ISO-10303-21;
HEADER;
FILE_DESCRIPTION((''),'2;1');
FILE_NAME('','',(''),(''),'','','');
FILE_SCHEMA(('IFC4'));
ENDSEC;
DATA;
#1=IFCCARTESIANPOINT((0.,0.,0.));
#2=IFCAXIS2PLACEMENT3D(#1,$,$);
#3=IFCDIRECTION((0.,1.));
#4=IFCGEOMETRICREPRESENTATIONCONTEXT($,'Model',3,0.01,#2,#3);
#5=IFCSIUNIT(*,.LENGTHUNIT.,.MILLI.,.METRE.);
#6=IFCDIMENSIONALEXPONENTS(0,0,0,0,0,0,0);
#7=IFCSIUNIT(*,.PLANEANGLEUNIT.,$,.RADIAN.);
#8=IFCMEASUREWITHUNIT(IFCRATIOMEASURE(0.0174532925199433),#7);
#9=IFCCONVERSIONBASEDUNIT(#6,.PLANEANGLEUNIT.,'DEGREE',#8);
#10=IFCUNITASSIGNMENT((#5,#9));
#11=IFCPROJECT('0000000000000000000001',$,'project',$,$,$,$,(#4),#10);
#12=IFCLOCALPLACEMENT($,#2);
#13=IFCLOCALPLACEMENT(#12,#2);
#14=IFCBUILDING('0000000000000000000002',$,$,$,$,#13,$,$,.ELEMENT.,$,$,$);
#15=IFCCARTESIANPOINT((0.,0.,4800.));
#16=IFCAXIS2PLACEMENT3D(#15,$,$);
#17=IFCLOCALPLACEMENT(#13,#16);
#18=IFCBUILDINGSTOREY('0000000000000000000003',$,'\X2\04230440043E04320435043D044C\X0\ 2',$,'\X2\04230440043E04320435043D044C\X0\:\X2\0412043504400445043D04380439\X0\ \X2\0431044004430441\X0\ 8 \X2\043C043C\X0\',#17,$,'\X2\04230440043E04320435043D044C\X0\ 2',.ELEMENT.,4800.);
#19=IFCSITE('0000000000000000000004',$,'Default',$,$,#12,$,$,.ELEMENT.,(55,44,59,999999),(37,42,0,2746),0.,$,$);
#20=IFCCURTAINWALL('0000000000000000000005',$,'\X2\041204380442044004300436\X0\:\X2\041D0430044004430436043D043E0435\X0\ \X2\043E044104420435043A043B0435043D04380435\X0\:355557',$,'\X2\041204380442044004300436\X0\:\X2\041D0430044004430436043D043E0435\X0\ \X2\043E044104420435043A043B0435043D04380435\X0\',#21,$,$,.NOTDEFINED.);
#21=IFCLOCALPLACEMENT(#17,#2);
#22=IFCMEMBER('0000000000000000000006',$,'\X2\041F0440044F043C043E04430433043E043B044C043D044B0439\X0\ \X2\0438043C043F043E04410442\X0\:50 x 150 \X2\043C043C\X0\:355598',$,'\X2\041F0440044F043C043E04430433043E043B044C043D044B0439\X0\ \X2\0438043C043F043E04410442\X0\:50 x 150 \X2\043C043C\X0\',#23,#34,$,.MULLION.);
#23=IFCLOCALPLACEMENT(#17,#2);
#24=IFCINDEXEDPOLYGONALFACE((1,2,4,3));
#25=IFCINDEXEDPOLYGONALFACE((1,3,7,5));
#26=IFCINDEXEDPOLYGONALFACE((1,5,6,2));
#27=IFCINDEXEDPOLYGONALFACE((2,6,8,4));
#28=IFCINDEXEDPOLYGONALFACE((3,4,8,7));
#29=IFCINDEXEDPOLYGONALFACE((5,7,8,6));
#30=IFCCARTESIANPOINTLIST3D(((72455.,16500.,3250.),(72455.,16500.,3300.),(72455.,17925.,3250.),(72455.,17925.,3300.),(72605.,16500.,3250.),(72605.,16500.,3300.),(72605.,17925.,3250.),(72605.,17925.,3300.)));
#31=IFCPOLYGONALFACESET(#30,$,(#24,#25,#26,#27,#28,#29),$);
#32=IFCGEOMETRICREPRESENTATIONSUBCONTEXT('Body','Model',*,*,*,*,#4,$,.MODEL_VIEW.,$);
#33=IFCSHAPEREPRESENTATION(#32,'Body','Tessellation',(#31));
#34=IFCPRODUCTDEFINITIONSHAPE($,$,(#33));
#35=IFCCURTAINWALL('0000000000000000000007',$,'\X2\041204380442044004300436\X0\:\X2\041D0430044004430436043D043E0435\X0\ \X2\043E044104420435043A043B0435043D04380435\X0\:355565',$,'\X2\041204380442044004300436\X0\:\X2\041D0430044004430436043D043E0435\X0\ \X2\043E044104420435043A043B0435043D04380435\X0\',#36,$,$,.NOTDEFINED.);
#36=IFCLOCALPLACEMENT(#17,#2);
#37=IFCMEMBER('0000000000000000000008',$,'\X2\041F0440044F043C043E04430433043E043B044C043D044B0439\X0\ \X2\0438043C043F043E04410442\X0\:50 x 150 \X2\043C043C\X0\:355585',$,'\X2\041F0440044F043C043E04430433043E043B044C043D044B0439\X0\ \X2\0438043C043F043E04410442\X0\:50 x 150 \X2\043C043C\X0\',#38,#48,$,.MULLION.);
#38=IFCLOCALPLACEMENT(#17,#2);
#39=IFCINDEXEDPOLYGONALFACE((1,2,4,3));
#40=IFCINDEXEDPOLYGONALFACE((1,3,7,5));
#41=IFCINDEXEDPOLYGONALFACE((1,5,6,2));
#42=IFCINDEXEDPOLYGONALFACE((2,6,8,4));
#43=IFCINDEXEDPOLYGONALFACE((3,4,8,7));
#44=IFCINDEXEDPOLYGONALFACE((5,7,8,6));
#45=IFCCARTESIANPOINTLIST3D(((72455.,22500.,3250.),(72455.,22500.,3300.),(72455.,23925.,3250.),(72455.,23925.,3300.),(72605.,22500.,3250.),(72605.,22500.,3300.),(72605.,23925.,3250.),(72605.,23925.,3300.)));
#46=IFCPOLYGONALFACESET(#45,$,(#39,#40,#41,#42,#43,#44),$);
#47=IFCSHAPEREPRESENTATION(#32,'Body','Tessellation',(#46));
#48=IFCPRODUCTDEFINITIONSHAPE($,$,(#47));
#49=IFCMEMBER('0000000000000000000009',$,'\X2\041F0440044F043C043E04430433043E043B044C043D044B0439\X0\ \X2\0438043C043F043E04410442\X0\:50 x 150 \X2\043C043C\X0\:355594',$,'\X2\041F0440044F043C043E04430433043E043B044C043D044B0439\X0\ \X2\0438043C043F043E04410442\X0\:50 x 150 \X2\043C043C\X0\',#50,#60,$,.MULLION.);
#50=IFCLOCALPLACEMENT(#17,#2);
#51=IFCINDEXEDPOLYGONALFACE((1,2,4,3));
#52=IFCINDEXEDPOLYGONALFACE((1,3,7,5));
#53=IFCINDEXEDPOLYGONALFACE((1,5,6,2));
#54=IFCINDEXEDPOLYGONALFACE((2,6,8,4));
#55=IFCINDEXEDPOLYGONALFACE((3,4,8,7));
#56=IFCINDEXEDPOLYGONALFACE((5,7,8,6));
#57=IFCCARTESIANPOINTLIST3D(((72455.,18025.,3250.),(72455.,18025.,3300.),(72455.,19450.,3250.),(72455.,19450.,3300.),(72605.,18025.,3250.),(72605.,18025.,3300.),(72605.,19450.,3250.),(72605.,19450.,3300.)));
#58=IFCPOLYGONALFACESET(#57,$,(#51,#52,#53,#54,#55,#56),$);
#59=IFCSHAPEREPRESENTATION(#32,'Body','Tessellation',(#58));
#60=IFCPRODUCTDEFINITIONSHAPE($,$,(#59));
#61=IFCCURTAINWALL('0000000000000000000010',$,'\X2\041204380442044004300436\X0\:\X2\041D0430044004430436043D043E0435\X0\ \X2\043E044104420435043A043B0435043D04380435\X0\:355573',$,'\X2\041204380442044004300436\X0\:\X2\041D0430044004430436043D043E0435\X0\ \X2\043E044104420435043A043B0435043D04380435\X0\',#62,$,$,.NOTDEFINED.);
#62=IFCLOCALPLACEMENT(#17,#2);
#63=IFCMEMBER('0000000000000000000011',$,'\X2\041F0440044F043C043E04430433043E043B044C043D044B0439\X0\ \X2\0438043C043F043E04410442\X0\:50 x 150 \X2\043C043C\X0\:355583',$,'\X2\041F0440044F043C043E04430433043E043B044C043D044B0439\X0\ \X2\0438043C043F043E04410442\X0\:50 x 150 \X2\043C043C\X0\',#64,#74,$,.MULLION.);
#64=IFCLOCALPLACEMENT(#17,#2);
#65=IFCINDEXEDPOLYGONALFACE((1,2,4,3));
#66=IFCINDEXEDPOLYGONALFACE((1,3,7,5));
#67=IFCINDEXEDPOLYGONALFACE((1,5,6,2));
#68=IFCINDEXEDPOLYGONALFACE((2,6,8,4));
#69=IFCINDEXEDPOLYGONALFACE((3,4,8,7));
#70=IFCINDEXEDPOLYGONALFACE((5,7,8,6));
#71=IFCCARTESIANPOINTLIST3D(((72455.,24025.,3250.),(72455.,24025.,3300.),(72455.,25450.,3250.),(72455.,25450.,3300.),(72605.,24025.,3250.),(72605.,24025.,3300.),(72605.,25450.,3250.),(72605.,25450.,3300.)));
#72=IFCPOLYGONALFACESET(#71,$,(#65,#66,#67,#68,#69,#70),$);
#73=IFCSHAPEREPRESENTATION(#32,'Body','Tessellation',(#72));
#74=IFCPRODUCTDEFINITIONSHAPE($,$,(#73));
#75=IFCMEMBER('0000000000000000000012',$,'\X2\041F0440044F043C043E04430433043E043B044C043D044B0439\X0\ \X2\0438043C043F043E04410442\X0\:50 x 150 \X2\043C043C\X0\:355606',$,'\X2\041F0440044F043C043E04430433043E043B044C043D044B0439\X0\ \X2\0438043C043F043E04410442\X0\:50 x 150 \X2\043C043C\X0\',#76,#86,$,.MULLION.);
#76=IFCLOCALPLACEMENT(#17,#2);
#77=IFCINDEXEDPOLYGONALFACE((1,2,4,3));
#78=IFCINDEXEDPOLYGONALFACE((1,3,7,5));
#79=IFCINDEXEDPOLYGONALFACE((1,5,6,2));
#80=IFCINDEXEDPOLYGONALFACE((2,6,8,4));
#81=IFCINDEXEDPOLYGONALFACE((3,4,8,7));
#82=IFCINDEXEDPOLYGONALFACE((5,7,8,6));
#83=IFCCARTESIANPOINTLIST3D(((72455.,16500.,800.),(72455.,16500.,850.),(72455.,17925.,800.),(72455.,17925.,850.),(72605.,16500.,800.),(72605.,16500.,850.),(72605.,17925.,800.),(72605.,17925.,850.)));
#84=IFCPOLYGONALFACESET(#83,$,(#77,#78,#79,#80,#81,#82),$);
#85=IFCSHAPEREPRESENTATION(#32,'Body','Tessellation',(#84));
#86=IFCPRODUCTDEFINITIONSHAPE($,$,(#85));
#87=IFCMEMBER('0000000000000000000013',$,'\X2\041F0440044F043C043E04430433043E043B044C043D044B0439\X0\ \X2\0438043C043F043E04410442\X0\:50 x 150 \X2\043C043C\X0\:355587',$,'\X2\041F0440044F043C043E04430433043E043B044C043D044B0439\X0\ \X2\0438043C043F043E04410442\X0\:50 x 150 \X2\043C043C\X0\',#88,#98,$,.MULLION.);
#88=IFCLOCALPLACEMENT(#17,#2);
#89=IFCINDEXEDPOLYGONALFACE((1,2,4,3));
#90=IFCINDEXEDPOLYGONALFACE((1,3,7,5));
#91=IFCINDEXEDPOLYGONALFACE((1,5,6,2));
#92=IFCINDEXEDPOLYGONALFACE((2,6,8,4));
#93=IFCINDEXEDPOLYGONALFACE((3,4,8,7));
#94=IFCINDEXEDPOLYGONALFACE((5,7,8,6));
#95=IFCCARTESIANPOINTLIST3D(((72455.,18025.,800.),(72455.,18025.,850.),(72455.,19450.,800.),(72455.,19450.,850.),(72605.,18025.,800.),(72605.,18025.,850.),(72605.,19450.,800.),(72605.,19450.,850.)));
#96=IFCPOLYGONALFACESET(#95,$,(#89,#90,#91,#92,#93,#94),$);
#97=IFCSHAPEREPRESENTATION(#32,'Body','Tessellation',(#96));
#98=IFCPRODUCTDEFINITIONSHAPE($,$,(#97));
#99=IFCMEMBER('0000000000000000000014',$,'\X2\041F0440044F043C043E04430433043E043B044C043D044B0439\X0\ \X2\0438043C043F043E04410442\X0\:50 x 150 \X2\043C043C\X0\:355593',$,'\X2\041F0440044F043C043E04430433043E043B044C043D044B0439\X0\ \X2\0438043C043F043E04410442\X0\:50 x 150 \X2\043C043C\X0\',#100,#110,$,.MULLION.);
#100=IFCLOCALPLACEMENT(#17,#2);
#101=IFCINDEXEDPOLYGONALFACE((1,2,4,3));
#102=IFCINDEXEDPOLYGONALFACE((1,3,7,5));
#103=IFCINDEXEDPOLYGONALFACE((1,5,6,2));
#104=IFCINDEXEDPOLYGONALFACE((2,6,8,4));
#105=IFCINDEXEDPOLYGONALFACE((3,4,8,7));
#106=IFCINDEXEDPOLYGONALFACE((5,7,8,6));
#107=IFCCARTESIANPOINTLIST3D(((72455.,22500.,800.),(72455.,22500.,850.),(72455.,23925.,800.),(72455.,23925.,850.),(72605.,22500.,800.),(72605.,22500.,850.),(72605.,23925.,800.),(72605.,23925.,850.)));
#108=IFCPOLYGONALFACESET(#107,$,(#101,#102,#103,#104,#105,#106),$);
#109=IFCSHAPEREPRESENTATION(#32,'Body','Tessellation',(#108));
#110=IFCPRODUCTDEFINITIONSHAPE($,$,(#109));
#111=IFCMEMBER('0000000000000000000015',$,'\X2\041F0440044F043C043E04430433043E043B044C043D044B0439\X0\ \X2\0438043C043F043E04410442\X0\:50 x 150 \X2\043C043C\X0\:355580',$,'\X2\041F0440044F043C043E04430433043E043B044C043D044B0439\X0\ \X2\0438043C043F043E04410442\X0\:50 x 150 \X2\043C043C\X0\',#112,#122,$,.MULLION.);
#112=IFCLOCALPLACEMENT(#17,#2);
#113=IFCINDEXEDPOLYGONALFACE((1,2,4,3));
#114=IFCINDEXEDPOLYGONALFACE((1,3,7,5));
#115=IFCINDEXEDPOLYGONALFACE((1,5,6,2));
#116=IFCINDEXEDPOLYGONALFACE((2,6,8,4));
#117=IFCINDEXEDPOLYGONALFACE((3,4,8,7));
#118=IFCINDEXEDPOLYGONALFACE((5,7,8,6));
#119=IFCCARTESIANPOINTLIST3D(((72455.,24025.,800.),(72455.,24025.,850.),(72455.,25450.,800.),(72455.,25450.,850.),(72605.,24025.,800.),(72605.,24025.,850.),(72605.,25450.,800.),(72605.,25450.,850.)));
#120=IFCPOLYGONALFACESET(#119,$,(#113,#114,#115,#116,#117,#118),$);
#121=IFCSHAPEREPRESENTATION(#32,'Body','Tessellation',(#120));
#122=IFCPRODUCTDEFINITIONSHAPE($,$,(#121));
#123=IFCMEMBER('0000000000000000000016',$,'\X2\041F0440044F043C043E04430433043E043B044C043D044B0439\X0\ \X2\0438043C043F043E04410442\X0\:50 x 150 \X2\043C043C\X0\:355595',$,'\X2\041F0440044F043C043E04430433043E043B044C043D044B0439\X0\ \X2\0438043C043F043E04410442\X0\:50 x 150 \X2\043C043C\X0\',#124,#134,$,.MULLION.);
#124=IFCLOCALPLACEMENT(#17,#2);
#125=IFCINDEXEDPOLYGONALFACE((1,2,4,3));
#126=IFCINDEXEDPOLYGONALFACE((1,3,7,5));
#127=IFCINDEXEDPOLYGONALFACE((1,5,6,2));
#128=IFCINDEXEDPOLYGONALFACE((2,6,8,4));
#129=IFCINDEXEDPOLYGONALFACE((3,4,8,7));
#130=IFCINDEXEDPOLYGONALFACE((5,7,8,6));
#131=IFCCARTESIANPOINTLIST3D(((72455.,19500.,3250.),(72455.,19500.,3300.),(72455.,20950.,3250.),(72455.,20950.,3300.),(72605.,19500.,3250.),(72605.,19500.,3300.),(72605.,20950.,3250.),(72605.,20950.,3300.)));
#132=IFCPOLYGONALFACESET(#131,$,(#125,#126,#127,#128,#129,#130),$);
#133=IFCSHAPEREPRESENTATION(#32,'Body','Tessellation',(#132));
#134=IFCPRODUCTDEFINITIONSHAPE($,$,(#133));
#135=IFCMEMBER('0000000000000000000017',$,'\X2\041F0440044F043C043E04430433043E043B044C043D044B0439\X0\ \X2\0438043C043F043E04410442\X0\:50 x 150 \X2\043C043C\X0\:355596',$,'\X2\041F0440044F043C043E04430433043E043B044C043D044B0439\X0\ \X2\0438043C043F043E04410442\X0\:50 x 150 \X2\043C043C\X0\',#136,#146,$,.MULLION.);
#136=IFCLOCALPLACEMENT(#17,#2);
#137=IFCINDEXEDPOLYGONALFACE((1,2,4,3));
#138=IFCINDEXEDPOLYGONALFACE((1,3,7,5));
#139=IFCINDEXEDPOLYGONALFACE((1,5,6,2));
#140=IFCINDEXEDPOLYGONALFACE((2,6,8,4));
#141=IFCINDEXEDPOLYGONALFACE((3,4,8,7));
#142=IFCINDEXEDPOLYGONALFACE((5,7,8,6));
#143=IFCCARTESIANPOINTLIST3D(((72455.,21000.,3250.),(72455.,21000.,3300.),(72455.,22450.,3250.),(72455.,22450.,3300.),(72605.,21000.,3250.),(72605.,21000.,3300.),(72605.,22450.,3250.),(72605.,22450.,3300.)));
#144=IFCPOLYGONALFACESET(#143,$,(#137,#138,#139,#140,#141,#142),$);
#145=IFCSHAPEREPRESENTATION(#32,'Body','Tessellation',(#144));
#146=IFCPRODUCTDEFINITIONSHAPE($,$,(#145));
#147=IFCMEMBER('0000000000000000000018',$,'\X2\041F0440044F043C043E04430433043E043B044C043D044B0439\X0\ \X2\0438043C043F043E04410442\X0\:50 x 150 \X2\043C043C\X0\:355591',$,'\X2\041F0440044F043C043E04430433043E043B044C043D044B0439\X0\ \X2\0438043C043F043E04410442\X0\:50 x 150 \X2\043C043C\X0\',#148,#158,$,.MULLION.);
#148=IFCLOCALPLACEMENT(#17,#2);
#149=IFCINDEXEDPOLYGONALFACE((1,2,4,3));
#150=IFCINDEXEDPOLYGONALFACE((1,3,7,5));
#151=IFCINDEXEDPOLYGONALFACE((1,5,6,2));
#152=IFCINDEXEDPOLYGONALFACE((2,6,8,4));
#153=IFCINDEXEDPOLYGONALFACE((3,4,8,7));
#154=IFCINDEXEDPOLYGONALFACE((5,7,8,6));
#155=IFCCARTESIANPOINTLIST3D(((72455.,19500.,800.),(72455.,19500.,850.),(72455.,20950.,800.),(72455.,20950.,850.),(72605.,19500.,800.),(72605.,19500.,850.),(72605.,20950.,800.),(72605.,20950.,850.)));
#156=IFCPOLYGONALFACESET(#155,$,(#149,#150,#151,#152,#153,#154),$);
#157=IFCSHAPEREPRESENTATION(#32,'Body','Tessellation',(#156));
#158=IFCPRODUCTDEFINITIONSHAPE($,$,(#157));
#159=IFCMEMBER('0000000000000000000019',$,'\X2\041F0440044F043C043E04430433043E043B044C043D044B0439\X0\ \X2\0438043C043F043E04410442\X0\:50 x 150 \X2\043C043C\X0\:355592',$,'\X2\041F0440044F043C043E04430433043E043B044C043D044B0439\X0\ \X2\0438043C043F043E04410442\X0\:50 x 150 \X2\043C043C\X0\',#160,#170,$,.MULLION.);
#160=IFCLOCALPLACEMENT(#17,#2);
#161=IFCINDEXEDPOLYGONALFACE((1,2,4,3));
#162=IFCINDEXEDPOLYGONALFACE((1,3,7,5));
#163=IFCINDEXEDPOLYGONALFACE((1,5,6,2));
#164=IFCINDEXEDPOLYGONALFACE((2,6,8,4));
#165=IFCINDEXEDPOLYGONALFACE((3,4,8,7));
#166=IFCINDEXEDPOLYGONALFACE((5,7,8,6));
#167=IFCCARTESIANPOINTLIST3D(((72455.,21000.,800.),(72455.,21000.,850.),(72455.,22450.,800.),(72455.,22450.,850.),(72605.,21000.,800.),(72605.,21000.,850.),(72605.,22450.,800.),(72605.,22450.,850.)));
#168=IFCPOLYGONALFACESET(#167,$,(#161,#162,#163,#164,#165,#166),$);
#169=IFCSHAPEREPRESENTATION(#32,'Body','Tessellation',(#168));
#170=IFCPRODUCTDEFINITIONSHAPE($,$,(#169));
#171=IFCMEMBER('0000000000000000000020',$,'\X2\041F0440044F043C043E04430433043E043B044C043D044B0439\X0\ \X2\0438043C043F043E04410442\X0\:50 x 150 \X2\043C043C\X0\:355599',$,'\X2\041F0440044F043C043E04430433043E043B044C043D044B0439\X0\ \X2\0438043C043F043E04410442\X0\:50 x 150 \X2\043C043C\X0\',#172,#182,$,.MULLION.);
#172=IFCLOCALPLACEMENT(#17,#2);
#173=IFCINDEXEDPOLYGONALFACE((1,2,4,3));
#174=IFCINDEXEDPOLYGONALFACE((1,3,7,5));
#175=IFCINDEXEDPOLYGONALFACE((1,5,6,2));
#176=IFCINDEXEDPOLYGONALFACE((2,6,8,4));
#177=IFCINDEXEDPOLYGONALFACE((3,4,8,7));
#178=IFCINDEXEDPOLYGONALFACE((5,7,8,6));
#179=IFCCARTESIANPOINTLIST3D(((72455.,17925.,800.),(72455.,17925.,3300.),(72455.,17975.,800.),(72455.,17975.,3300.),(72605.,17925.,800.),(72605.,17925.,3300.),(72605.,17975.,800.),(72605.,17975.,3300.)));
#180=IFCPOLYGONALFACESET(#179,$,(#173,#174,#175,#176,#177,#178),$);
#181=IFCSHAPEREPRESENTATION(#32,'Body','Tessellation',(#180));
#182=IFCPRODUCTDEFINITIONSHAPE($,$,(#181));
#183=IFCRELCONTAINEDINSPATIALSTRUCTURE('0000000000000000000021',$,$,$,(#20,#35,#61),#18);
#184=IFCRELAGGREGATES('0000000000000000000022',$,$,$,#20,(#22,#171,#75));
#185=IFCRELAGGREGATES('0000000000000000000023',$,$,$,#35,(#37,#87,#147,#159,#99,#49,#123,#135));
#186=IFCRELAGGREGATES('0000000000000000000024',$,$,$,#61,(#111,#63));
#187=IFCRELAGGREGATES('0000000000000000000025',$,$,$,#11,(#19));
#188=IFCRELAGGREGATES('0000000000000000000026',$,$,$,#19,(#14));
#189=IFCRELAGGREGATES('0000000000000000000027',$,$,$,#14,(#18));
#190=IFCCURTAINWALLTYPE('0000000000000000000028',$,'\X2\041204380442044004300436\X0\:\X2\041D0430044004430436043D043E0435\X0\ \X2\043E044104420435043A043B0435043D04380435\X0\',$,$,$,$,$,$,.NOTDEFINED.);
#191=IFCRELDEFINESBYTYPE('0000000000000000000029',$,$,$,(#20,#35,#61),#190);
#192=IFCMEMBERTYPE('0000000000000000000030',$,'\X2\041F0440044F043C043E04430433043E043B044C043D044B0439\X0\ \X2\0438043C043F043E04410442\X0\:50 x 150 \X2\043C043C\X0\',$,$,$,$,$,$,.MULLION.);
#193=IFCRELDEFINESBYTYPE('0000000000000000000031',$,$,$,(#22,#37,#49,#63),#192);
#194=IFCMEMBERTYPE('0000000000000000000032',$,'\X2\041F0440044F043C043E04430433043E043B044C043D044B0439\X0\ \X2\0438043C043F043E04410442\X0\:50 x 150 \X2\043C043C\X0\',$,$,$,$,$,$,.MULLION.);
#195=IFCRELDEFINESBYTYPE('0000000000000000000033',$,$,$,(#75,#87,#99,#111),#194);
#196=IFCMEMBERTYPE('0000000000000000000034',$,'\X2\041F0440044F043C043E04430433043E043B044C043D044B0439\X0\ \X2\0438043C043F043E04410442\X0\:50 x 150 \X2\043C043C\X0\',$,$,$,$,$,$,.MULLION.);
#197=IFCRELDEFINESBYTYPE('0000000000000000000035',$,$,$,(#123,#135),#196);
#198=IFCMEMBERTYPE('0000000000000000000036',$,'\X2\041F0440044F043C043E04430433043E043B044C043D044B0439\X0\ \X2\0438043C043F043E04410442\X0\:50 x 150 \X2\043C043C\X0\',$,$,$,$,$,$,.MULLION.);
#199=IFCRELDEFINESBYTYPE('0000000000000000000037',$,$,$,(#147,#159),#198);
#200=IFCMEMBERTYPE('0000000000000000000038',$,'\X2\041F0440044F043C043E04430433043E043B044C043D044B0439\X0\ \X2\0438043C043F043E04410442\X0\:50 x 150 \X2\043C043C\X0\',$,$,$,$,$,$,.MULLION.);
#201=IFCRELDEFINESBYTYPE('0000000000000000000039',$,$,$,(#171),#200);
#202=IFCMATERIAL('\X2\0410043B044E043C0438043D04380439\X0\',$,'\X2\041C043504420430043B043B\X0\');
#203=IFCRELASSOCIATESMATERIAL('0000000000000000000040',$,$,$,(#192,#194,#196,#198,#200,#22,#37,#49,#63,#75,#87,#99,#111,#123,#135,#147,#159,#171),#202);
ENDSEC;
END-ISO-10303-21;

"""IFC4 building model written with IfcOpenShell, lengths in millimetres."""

from ifc_helpers import new_model, entity, si_unit, converted_unit, direction, frame, origin, origin_2d_with_axis, place, context, subcontext, project, spatial, rectangle, extrude, source, transform, mapped, material, material_profile, profile_set, profile_usage, type_object, type_shapes, element, aggregate, save


model = new_model("IFC4")

# Units and contexts
model_context = context("Model", 3, precision=0.01, world=origin(), true_north=direction((0.0, 1.0)))
body_context = subcontext(model_context, "Body", "Model", "MODEL_VIEW")
ifc_project = project(units=[si_unit("LENGTHUNIT", "METRE", prefix="MILLI"), converted_unit("PLANEANGLEUNIT", "DEGREE", entity("IfcRatioMeasure", 0.0174532925199433), si_unit("PLANEANGLEUNIT", "RADIAN"), dimensions=[0, 0, 0, 0, 0, 0, 0])], contexts=[model_context])

# Site, building, storey
site_placement = place(None, origin())
site = spatial("IfcSite", under=ifc_project, at=site_placement, Name="Default", CompositionType="ELEMENT", RefLatitude=(55, 44, 59, 999999), RefLongitude=(37, 42, 0, 2746), RefElevation=0.0)
building_placement = place(site_placement, origin())
building = spatial("IfcBuilding", under=site, at=building_placement, CompositionType="ELEMENT")
storey_placement = place(building_placement, frame((0.0, 0.0, 4800.0)))
storey = spatial("IfcBuildingStorey", under=building, at=storey_placement, Name="Уровень 2", ObjectType="Уровень:Верхний брус 8 мм", LongName="Уровень 2", CompositionType="ELEMENT", Elevation=4800.0)

# Curtain wall, member
curtain_wall_type = type_object("IfcCurtainWallType", Name="Витраж:Наружное остекление", PredefinedType="NOTDEFINED")
curtain_wall_1_placement = place(storey_placement, frame((0.0, 0.0, -4800.0)))
curtain_wall_1 = element("IfcCurtainWall", 1, at=curtain_wall_1_placement, inside=storey, type_object=curtain_wall_type, Name="Витраж:Наружное остекление:355557", ObjectType="Витраж:Наружное остекление", PredefinedType="NOTDEFINED")
ifc_material = material(Name="Алюминий", Category="Металл")
ifc_material_profile = material_profile(ifc_material, rectangle(XDim=150.0, YDim=50.0, at=origin_2d_with_axis()), Name="50 x 150 мм")
ifc_profile_set = profile_set([ifc_material_profile], Name="50 x 150 мм")
ifc_profile_usage_1 = profile_usage(ifc_profile_set)
member_type_1 = type_object("IfcMemberType", Name="Прямоугольный импост:50 x 150 мм", PredefinedType="MULLION", material=ifc_profile_set)
shared_shape_1 = source(origin(), body_context, "Body", "SweptSolid", [
    extrude(rectangle(XDim=150.0, YDim=50.0, at=origin_2d_with_axis()), frame((-25.0, 0.0, -1425.0), z_axis=(0.0, 0.0, 1.0), x_axis=(0.0, -1.0, 0.0)), (0.0, 0.0, 1.0), 1425.0),
])
type_shapes(member_type_1, [shared_shape_1])
member_1_placement = place(storey_placement, frame((72530.0, 17925.0, 3300.0), z_axis=(0.0, 1.0, 0.0), x_axis=(0.0, 0.0, 1.0)))
member_1 = element("IfcMember", 2, at=member_1_placement, type_object=member_type_1, material=ifc_profile_usage_1, Name="Прямоугольный импост:50 x 150 мм:355598", ObjectType="Прямоугольный импост:50 x 150 мм", PredefinedType="MULLION", context=body_context, shape_type="MappedRepresentation", body=[
    mapped(shared_shape_1, transform((0.0, 0.0, 0.0), scale=1.0)),
])

# Curtain wall, members
curtain_wall_2_placement = place(storey_placement, frame((0.0, 0.0, -4800.0)))
curtain_wall_2 = element("IfcCurtainWall", 3, at=curtain_wall_2_placement, inside=storey, type_object=curtain_wall_type, Name="Витраж:Наружное остекление:355565", ObjectType="Витраж:Наружное остекление", PredefinedType="NOTDEFINED")
ifc_profile_usage_2 = profile_usage(ifc_profile_set)
member_2_placement = place(storey_placement, frame((72530.0, 23925.0, 3300.0), z_axis=(0.0, 1.0, 0.0), x_axis=(0.0, 0.0, 1.0)))
member_2 = element("IfcMember", 4, at=member_2_placement, type_object=member_type_1, material=ifc_profile_usage_2, Name="Прямоугольный импост:50 x 150 мм:355585", ObjectType="Прямоугольный импост:50 x 150 мм", PredefinedType="MULLION", context=body_context, shape_type="MappedRepresentation", body=[
    mapped(shared_shape_1, transform((0.0, 0.0, 0.0), scale=1.0)),
])
ifc_profile_usage_3 = profile_usage(ifc_profile_set)
member_3_placement = place(storey_placement, frame((72530.0, 19450.0, 3300.0), z_axis=(0.0, 1.0, 0.0), x_axis=(0.0, 0.0, 1.0)))
member_3 = element("IfcMember", 5, at=member_3_placement, type_object=member_type_1, material=ifc_profile_usage_3, Name="Прямоугольный импост:50 x 150 мм:355594", ObjectType="Прямоугольный импост:50 x 150 мм", PredefinedType="MULLION", context=body_context, shape_type="MappedRepresentation", body=[
    mapped(shared_shape_1, transform((0.0, 0.0, 0.0), scale=1.0)),
])

# Curtain wall, member
curtain_wall_3_placement = place(storey_placement, frame((0.0, 0.0, -4800.0)))
curtain_wall_3 = element("IfcCurtainWall", 6, at=curtain_wall_3_placement, inside=storey, type_object=curtain_wall_type, Name="Витраж:Наружное остекление:355573", ObjectType="Витраж:Наружное остекление", PredefinedType="NOTDEFINED")
ifc_profile_usage_4 = profile_usage(ifc_profile_set)
member_4_placement = place(storey_placement, frame((72530.0, 25450.0, 3300.0), z_axis=(0.0, 1.0, 0.0), x_axis=(0.0, 0.0, 1.0)))
member_4 = element("IfcMember", 7, at=member_4_placement, type_object=member_type_1, material=ifc_profile_usage_4, Name="Прямоугольный импост:50 x 150 мм:355583", ObjectType="Прямоугольный импост:50 x 150 мм", PredefinedType="MULLION", context=body_context, shape_type="MappedRepresentation", body=[
    mapped(shared_shape_1, transform((0.0, 0.0, 0.0), scale=1.0)),
])

# Members
ifc_profile_usage_5 = profile_usage(ifc_profile_set)
member_type_2 = type_object("IfcMemberType", Name="Прямоугольный импост:50 x 150 мм", PredefinedType="MULLION", material=ifc_profile_set)
shared_shape_2 = source(origin(), body_context, "Body", "SweptSolid", [
    extrude(rectangle(XDim=150.0, YDim=50.0, at=origin_2d_with_axis()), frame((-25.0, 0.0, -1425.0), z_axis=(0.0, 0.0, 1.0), x_axis=(0.0, -1.0, 0.0)), (0.0, 0.0, 1.0), 1425.0),
])
type_shapes(member_type_2, [shared_shape_2])
member_5_placement = place(storey_placement, frame((72530.0, 16500.0, 800.0), z_axis=(0.0, -1.0, 0.0), x_axis=(0.0, 0.0, -1.0)))
member_5 = element("IfcMember", 8, at=member_5_placement, type_object=member_type_2, material=ifc_profile_usage_5, Name="Прямоугольный импост:50 x 150 мм:355606", ObjectType="Прямоугольный импост:50 x 150 мм", PredefinedType="MULLION", context=body_context, shape_type="MappedRepresentation", body=[
    mapped(shared_shape_2, transform((0.0, 0.0, 0.0), scale=1.0)),
])
ifc_profile_usage_6 = profile_usage(ifc_profile_set)
member_6_placement = place(storey_placement, frame((72530.0, 18025.0, 800.0), z_axis=(0.0, -1.0, 0.0), x_axis=(0.0, 0.0, -1.0)))
member_6 = element("IfcMember", 9, at=member_6_placement, type_object=member_type_2, material=ifc_profile_usage_6, Name="Прямоугольный импост:50 x 150 мм:355587", ObjectType="Прямоугольный импост:50 x 150 мм", PredefinedType="MULLION", context=body_context, shape_type="MappedRepresentation", body=[
    mapped(shared_shape_2, transform((0.0, 0.0, 0.0), scale=1.0)),
])
ifc_profile_usage_7 = profile_usage(ifc_profile_set)
member_7_placement = place(storey_placement, frame((72530.0, 22500.0, 800.0), z_axis=(0.0, -1.0, 0.0), x_axis=(0.0, 0.0, -1.0)))
member_7 = element("IfcMember", 10, at=member_7_placement, type_object=member_type_2, material=ifc_profile_usage_7, Name="Прямоугольный импост:50 x 150 мм:355593", ObjectType="Прямоугольный импост:50 x 150 мм", PredefinedType="MULLION", context=body_context, shape_type="MappedRepresentation", body=[
    mapped(shared_shape_2, transform((0.0, 0.0, 0.0), scale=1.0)),
])
ifc_profile_usage_8 = profile_usage(ifc_profile_set)
member_8_placement = place(storey_placement, frame((72530.0, 24025.0, 800.0), z_axis=(0.0, -1.0, 0.0), x_axis=(0.0, 0.0, -1.0)))
member_8 = element("IfcMember", 11, at=member_8_placement, type_object=member_type_2, material=ifc_profile_usage_8, Name="Прямоугольный импост:50 x 150 мм:355580", ObjectType="Прямоугольный импост:50 x 150 мм", PredefinedType="MULLION", context=body_context, shape_type="MappedRepresentation", body=[
    mapped(shared_shape_2, transform((0.0, 0.0, 0.0), scale=1.0)),
])
ifc_profile_usage_9 = profile_usage(ifc_profile_set)
member_type_3 = type_object("IfcMemberType", Name="Прямоугольный импост:50 x 150 мм", PredefinedType="MULLION", material=ifc_profile_set)
shared_shape_3 = source(origin(), body_context, "Body", "SweptSolid", [
    extrude(rectangle(XDim=150.0, YDim=50.0, at=origin_2d_with_axis()), frame((-25.0, 0.0, -1450.0), z_axis=(0.0, 0.0, 1.0), x_axis=(0.0, -1.0, 0.0)), (0.0, 0.0, 1.0), 1450.0),
])
type_shapes(member_type_3, [shared_shape_3])
member_9_placement = place(storey_placement, frame((72530.0, 20950.0, 3300.0), z_axis=(0.0, 1.0, 0.0), x_axis=(0.0, 0.0, 1.0)))
member_9 = element("IfcMember", 12, at=member_9_placement, type_object=member_type_3, material=ifc_profile_usage_9, Name="Прямоугольный импост:50 x 150 мм:355595", ObjectType="Прямоугольный импост:50 x 150 мм", PredefinedType="MULLION", context=body_context, shape_type="MappedRepresentation", body=[
    mapped(shared_shape_3, transform((0.0, 0.0, 0.0), scale=1.0)),
])
ifc_profile_usage_10 = profile_usage(ifc_profile_set)
member_10_placement = place(storey_placement, frame((72530.0, 22450.0, 3300.0), z_axis=(0.0, 1.0, 0.0), x_axis=(0.0, 0.0, 1.0)))
member_10 = element("IfcMember", 13, at=member_10_placement, type_object=member_type_3, material=ifc_profile_usage_10, Name="Прямоугольный импост:50 x 150 мм:355596", ObjectType="Прямоугольный импост:50 x 150 мм", PredefinedType="MULLION", context=body_context, shape_type="MappedRepresentation", body=[
    mapped(shared_shape_3, transform((0.0, 0.0, 0.0), scale=1.0)),
])
ifc_profile_usage_11 = profile_usage(ifc_profile_set)
member_type_4 = type_object("IfcMemberType", Name="Прямоугольный импост:50 x 150 мм", PredefinedType="MULLION", material=ifc_profile_set)
shared_shape_4 = source(origin(), body_context, "Body", "SweptSolid", [
    extrude(rectangle(XDim=150.0, YDim=50.0, at=origin_2d_with_axis()), frame((-25.0, 0.0, -1450.0), z_axis=(0.0, 0.0, 1.0), x_axis=(0.0, -1.0, 0.0)), (0.0, 0.0, 1.0), 1450.0),
])
type_shapes(member_type_4, [shared_shape_4])
member_11_placement = place(storey_placement, frame((72530.0, 19500.0, 800.0), z_axis=(0.0, -1.0, 0.0), x_axis=(0.0, 0.0, -1.0)))
member_11 = element("IfcMember", 14, at=member_11_placement, type_object=member_type_4, material=ifc_profile_usage_11, Name="Прямоугольный импост:50 x 150 мм:355591", ObjectType="Прямоугольный импост:50 x 150 мм", PredefinedType="MULLION", context=body_context, shape_type="MappedRepresentation", body=[
    mapped(shared_shape_4, transform((0.0, 0.0, 0.0), scale=1.0)),
])
ifc_profile_usage_12 = profile_usage(ifc_profile_set)
member_12_placement = place(storey_placement, frame((72530.0, 21000.0, 800.0), z_axis=(0.0, -1.0, 0.0), x_axis=(0.0, 0.0, -1.0)))
member_12 = element("IfcMember", 15, at=member_12_placement, type_object=member_type_4, material=ifc_profile_usage_12, Name="Прямоугольный импост:50 x 150 мм:355592", ObjectType="Прямоугольный импост:50 x 150 мм", PredefinedType="MULLION", context=body_context, shape_type="MappedRepresentation", body=[
    mapped(shared_shape_4, transform((0.0, 0.0, 0.0), scale=1.0)),
])
ifc_profile_usage_13 = profile_usage(ifc_profile_set)
member_type_5 = type_object("IfcMemberType", Name="Прямоугольный импост:50 x 150 мм", PredefinedType="MULLION", material=ifc_profile_set)
shared_shape_5 = source(origin(), body_context, "Body", "SweptSolid", [
    extrude(rectangle(XDim=150.0, YDim=50.0, at=origin_2d_with_axis()), frame((-25.0, 0.0, -2500.0), z_axis=(0.0, 0.0, 1.0), x_axis=(0.0, -1.0, 0.0)), (0.0, 0.0, 1.0), 2500.0),
])
type_shapes(member_type_5, [shared_shape_5])
member_13_placement = place(storey_placement, frame((72530.0, 17975.0, 800.0), z_axis=(0.0, 0.0, -1.0), x_axis=(0.0, 1.0, 0.0)))
member_13 = element("IfcMember", 16, at=member_13_placement, type_object=member_type_5, material=ifc_profile_usage_13, Name="Прямоугольный импост:50 x 150 мм:355599", ObjectType="Прямоугольный импост:50 x 150 мм", PredefinedType="MULLION", context=body_context, shape_type="MappedRepresentation", body=[
    mapped(shared_shape_5, transform((0.0, 0.0, 0.0), scale=1.0)),
])
aggregate(curtain_wall_1, [member_1, member_13, member_5])
aggregate(curtain_wall_2, [member_2, member_6, member_11, member_12, member_7, member_3, member_9, member_10])
aggregate(curtain_wall_3, [member_8, member_4])

save(model, "model.ifc")
